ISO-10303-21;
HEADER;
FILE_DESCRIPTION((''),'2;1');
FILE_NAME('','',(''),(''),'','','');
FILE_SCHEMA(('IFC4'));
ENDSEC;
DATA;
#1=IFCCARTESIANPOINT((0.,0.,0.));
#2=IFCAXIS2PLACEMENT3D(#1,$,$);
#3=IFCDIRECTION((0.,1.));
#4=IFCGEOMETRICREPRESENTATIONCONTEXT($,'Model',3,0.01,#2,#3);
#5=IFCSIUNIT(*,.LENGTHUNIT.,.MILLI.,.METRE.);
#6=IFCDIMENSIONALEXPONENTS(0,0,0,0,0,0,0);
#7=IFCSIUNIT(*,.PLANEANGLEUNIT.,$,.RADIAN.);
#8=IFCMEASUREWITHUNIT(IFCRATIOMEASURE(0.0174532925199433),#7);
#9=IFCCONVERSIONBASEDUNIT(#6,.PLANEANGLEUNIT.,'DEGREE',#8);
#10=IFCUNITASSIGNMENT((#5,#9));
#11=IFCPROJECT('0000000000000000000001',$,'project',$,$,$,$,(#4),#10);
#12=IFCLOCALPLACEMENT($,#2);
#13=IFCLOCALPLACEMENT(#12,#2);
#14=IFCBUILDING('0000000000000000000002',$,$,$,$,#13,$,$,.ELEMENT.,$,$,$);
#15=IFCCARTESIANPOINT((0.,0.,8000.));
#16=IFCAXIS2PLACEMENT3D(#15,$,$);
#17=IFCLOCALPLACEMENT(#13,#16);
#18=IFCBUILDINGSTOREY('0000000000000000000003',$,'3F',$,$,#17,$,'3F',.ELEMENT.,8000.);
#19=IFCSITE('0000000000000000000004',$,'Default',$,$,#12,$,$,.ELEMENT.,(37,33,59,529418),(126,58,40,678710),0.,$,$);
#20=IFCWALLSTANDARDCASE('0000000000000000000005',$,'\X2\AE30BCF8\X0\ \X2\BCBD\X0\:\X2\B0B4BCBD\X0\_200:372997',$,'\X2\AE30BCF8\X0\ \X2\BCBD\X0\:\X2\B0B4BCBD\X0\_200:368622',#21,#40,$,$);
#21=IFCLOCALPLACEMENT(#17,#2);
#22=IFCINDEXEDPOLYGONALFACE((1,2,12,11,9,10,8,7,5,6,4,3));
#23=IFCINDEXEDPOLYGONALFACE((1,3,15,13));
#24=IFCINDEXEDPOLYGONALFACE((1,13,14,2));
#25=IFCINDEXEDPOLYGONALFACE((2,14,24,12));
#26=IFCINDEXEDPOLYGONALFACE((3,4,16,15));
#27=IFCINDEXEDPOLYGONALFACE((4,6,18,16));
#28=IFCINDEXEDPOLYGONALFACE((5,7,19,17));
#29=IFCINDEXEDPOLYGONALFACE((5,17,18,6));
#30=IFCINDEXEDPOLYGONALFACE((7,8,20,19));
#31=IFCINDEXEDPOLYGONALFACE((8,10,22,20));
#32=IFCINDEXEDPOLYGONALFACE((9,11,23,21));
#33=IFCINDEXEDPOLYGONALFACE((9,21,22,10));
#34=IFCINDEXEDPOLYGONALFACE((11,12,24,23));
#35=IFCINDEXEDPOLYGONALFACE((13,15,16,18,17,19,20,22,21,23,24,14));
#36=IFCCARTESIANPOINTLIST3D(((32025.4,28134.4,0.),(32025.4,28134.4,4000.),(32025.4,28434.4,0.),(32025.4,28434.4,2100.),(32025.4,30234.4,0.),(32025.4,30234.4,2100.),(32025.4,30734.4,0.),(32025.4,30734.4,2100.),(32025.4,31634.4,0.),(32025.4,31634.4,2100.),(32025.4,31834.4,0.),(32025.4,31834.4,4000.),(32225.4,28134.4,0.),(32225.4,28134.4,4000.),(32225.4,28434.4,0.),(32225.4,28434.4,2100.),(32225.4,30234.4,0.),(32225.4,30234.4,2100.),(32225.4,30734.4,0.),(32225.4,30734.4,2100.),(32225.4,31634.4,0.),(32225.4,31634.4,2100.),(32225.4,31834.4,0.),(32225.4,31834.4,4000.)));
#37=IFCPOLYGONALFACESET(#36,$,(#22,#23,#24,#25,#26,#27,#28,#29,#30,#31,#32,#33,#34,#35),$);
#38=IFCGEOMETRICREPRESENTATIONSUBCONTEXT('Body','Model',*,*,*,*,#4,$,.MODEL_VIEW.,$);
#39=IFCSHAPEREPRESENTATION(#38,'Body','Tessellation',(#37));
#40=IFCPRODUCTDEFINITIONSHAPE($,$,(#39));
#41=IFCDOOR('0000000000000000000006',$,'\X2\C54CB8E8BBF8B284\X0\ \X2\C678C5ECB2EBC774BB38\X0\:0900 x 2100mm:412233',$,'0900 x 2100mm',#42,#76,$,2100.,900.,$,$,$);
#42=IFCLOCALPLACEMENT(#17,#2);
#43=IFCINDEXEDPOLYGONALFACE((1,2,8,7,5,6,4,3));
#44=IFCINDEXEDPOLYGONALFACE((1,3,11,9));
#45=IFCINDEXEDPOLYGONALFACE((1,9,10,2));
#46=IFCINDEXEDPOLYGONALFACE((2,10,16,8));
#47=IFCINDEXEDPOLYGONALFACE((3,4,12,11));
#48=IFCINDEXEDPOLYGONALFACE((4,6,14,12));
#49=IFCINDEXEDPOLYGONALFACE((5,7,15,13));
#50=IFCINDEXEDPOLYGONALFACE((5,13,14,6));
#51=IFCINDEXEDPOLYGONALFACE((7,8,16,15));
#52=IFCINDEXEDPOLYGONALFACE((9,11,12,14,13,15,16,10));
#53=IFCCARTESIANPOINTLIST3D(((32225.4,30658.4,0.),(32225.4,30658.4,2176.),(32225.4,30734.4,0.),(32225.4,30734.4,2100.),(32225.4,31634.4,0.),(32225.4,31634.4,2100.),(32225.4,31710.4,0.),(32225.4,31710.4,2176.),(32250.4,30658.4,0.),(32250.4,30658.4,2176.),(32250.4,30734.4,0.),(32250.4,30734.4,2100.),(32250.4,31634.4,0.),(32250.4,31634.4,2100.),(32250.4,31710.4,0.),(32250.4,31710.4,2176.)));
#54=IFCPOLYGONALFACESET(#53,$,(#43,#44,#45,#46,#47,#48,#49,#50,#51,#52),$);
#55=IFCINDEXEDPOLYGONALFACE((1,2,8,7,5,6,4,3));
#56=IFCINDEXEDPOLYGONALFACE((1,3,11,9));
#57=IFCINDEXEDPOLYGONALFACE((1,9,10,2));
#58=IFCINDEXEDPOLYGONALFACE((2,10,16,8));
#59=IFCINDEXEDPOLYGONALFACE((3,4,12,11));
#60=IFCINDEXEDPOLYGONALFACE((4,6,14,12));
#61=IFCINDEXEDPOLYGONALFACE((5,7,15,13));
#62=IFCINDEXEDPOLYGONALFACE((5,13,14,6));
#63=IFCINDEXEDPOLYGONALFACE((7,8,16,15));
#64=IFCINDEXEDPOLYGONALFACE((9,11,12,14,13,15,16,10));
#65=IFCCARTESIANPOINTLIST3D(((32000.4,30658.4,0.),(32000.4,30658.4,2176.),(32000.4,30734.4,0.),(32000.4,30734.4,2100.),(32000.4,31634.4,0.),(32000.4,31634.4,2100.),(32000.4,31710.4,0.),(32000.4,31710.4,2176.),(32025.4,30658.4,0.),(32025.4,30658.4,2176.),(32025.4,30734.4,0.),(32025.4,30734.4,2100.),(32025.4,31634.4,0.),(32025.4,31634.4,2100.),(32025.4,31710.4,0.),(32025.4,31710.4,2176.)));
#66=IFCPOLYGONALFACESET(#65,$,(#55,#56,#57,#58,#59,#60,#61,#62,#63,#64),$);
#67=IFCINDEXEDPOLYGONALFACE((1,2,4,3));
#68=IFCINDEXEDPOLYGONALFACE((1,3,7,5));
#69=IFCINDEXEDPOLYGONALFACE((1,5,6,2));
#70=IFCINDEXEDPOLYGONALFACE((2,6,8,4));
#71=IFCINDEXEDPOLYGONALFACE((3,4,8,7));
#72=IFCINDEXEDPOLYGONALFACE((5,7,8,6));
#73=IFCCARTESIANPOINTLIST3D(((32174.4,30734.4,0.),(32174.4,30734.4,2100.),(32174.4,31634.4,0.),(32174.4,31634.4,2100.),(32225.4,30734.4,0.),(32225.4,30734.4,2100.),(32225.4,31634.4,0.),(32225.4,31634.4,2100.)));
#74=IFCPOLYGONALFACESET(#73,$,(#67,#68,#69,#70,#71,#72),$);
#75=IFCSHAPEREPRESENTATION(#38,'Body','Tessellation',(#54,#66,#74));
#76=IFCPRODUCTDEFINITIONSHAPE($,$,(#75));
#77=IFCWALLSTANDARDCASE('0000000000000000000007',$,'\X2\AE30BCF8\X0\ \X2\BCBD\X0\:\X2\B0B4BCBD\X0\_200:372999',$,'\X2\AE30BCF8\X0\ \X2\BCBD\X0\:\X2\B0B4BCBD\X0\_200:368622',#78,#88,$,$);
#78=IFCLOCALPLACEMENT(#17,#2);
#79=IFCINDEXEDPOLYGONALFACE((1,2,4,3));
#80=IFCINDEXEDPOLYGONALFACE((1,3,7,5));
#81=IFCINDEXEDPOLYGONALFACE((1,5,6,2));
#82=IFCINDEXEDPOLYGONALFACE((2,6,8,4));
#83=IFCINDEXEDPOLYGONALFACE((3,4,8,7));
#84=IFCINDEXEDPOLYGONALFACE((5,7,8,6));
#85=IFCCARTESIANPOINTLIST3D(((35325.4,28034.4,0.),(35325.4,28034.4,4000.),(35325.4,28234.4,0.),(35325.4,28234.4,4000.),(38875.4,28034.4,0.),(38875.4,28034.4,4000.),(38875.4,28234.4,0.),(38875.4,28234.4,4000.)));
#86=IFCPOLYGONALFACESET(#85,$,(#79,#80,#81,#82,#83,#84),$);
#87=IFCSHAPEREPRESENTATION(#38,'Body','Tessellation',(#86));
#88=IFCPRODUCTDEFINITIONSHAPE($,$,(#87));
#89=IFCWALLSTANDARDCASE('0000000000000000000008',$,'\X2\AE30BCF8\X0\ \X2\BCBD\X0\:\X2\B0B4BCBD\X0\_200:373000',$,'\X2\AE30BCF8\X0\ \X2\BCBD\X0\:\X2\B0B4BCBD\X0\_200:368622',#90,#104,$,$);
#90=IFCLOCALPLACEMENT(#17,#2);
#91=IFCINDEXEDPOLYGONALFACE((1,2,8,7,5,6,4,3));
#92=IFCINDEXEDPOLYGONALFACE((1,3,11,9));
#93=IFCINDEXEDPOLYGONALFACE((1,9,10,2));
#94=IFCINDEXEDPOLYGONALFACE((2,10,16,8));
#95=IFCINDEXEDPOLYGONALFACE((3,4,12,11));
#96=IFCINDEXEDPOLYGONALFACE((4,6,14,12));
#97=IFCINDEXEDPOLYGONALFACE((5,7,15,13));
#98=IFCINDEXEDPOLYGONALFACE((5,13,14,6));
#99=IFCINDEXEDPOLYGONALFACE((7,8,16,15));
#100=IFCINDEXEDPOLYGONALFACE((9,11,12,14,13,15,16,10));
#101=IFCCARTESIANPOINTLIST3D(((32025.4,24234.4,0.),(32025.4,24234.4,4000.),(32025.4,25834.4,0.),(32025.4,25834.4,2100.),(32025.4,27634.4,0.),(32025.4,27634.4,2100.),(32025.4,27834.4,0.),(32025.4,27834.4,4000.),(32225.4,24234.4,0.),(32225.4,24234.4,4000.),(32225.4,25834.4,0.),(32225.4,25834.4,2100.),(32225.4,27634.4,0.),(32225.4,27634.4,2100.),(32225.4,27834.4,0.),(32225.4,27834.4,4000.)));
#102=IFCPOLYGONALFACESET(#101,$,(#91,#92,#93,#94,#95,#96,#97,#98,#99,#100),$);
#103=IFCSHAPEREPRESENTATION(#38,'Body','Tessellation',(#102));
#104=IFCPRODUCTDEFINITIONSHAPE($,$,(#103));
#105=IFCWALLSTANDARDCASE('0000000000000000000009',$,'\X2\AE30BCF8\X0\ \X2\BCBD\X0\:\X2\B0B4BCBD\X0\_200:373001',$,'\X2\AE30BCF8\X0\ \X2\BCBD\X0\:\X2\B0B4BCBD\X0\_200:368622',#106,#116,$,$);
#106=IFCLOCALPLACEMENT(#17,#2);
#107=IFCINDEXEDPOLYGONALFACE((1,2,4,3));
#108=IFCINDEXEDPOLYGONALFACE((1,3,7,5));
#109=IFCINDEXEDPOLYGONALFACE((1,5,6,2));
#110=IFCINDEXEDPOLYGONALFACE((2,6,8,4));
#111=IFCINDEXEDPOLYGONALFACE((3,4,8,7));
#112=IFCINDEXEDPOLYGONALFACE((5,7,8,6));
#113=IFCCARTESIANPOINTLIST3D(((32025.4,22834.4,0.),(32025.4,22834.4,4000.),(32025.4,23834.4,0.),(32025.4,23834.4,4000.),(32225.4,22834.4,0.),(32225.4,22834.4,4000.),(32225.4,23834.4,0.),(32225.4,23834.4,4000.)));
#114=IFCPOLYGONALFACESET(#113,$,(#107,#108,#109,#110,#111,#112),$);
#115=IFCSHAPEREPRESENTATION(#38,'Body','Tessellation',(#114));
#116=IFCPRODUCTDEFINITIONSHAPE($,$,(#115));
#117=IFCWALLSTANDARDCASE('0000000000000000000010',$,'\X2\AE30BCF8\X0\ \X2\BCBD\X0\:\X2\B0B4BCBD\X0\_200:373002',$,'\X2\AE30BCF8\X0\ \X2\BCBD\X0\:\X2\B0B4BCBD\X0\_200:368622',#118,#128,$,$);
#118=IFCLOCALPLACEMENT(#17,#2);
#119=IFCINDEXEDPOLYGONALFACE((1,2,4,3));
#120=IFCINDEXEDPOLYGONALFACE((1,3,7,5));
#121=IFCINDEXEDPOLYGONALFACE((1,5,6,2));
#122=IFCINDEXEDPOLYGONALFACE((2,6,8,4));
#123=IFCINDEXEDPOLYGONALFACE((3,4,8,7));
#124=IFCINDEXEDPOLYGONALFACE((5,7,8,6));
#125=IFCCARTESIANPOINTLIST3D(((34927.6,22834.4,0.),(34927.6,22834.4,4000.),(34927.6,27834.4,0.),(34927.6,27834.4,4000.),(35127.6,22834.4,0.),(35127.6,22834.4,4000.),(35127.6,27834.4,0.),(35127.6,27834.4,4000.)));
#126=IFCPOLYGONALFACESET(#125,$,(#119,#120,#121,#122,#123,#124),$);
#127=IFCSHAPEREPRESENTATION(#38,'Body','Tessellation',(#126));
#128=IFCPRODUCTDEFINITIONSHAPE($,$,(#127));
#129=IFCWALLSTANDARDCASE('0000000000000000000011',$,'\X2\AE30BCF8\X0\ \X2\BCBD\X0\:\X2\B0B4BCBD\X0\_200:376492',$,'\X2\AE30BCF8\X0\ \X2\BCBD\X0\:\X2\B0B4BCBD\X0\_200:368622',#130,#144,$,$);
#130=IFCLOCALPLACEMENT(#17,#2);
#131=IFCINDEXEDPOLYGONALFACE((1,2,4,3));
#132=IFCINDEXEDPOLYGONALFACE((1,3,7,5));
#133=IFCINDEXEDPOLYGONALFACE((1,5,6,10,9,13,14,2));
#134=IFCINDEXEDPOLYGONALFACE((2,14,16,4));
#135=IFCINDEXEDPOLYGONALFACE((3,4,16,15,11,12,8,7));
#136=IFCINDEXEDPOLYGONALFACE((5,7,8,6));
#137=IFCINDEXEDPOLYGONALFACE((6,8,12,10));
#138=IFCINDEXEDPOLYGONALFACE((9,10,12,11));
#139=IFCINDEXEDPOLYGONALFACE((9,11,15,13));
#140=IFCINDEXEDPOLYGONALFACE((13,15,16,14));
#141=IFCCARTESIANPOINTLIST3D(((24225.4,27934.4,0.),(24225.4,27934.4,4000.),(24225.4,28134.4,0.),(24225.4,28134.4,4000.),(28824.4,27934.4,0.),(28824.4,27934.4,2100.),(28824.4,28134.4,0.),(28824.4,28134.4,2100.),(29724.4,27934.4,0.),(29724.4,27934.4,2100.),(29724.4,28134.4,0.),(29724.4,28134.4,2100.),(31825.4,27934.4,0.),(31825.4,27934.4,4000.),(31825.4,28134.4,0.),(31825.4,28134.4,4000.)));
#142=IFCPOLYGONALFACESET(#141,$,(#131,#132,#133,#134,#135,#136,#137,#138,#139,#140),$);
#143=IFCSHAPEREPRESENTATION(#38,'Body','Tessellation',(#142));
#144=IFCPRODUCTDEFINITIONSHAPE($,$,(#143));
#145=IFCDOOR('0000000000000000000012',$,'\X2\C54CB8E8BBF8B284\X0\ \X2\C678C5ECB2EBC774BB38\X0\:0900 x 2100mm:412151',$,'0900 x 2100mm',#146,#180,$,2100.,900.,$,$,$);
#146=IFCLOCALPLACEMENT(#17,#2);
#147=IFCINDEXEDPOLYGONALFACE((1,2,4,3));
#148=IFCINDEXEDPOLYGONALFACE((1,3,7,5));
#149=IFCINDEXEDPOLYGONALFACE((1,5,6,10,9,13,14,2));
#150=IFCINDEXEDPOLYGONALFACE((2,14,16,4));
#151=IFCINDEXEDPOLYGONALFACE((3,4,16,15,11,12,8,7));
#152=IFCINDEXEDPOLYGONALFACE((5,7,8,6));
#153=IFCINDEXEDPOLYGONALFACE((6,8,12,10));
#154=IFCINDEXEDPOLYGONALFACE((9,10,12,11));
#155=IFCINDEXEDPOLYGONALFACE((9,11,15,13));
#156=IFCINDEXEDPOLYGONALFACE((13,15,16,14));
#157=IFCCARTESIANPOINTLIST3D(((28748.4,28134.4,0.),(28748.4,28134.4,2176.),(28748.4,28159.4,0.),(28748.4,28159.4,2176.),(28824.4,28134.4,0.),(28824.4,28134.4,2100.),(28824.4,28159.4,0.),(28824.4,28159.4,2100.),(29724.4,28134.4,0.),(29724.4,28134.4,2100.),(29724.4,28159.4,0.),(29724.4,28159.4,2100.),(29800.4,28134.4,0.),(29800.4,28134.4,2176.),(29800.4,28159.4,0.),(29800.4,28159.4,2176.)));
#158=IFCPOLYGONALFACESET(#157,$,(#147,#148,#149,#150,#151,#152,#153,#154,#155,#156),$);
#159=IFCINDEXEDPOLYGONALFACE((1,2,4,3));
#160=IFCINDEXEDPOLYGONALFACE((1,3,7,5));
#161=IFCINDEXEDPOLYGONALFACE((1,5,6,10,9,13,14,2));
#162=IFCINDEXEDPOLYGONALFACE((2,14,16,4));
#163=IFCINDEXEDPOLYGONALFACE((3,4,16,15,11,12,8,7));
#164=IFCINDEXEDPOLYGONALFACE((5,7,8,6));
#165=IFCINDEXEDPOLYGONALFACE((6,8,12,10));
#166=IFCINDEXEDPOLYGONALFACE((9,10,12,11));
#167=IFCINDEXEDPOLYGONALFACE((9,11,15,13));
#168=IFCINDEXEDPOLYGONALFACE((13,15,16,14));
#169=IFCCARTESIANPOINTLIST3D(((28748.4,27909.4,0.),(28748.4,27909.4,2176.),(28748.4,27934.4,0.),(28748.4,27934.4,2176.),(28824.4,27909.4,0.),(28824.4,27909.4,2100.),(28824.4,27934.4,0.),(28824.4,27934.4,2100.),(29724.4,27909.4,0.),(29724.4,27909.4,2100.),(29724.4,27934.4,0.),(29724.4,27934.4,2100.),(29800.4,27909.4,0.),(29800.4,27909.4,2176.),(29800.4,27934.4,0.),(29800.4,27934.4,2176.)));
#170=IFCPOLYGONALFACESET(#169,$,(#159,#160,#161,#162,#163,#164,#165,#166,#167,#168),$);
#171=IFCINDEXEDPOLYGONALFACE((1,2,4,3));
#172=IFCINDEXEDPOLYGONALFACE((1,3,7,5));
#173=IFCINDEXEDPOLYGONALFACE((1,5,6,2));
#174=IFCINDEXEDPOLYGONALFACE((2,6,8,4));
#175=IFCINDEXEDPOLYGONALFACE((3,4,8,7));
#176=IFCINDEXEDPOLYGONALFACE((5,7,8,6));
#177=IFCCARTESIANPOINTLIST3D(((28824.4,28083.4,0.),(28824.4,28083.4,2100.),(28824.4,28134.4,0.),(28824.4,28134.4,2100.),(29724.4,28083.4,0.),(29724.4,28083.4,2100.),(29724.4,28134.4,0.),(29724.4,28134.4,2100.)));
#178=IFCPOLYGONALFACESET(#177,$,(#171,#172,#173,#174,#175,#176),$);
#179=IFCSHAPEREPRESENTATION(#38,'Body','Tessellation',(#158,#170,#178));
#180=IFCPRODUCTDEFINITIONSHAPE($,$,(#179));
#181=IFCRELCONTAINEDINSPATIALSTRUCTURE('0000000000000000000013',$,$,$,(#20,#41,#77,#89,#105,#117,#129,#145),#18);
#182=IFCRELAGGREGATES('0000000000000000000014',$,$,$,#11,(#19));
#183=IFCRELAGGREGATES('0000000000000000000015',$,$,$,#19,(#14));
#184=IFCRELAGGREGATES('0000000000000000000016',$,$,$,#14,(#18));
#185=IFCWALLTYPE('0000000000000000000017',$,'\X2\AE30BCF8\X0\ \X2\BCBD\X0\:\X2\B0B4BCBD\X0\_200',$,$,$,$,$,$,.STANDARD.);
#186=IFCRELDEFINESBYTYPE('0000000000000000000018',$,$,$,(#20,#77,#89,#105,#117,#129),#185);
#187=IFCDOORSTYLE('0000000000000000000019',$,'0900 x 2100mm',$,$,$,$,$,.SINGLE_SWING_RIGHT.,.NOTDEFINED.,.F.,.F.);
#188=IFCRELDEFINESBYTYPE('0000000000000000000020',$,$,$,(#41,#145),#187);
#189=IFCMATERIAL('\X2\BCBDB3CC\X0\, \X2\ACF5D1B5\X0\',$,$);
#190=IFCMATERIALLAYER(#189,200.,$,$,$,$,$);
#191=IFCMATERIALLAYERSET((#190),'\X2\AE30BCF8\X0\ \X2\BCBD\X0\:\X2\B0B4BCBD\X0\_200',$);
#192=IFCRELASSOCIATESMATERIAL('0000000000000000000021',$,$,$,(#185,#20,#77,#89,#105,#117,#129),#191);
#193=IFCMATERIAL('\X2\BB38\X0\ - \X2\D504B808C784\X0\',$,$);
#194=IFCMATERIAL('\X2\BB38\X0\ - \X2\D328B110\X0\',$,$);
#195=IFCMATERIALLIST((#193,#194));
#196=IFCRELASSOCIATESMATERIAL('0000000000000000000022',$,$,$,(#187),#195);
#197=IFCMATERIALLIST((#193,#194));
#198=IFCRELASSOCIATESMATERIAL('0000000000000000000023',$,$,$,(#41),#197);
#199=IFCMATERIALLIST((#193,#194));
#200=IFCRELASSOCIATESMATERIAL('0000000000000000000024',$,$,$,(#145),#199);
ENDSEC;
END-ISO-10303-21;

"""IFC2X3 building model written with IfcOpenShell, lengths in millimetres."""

from ifc_helpers import new_model, entity, si_unit, converted_unit, direction, frame, frame_2d, origin, place, context, subcontext, project, spatial, polyline, rectangle, outline, extrude, source, transform, mapped, material, material_list, layer, layer_set, layer_usage, type_object, type_shapes, element, fill, save


model = new_model("IFC2X3")

# Units and contexts
model_context = context("Model", 3, precision=0.01, world=origin(), true_north=direction((0.0, 1.0)))
body_context = subcontext(model_context, "Body", "Model", "MODEL_VIEW")
ifc_project = project(units=[si_unit("LENGTHUNIT", "METRE", prefix="MILLI"), converted_unit("PLANEANGLEUNIT", "DEGREE", entity("IfcRatioMeasure", 0.0174532925199433), si_unit("PLANEANGLEUNIT", "RADIAN"), dimensions=[0, 0, 0, 0, 0, 0, 0])], contexts=[model_context])

# Site, building, storey
site_placement = place(None, origin())
site = spatial("IfcSite", under=ifc_project, at=site_placement, Name="Default", CompositionType="ELEMENT", RefLatitude=(37, 33, 59, 529418), RefLongitude=(126, 58, 40, 678710), RefElevation=0.0)
building_placement = place(site_placement, origin())
building = spatial("IfcBuilding", under=site, at=building_placement, CompositionType="ELEMENT")
storey_placement = place(building_placement, frame((0.0, 0.0, 8000.0)))
storey = spatial("IfcBuildingStorey", under=building, at=storey_placement, Name="3F", LongName="3F", CompositionType="ELEMENT", Elevation=8000.0)

# Wall, openings, door
ifc_material_1 = material(Name="벽돌, 공통")
ifc_layer_1 = layer(ifc_material_1, 200.0)
ifc_layer_set_1 = layer_set([ifc_layer_1], Name="기본 벽:내벽_200")
ifc_layer_usage_1 = layer_usage(ifc_layer_set_1, "AXIS2", "NEGATIVE", 100.0)
wall_type_1 = type_object("IfcWallType", Name="기본 벽:내벽_200", PredefinedType="STANDARD", material=ifc_layer_set_1)
wall_1_placement = place(storey_placement, frame((32125.4, 31834.4, 0.0), z_axis=(0.0, 0.0, 1.0), x_axis=(0.0, -1.0, 0.0)))
wall_1 = element("IfcWallStandardCase", 1, at=wall_1_placement, inside=storey, type_object=wall_type_1, material=ifc_layer_usage_1, Name="기본 벽:내벽_200:372997", ObjectType="기본 벽:내벽_200:368622", context=body_context, shape_type="SweptSolid", body=[
    extrude(rectangle(XDim=3700.0, YDim=200.0, at=frame_2d((1850.0, 0.0), x_axis=(-1.0, 0.0))), origin(), (0.0, 0.0, 1.0), 4000.0),
])
opening_1_placement = place(wall_1_placement, frame((200.0, -100.0, 0.0)))
opening_1 = element("IfcOpeningElement", 2, at=opening_1_placement, cuts=wall_1, ObjectType="Opening", context=body_context, shape_type="SweptSolid", body=[
    extrude(rectangle(XDim=900.0, YDim=2100.0, at=frame_2d((1050.0, 450.0), x_axis=(0.0, 1.0))), frame((0.0, 0.0, 0.0), z_axis=(0.0, 1.0, 0.0), x_axis=(0.0, 0.0, 1.0)), (0.0, 0.0, 1.0), 200.0),
])
opening_2_placement = place(wall_1_placement, frame((3400.0, 100.0, 0.0)))
element("IfcOpeningElement", 3, at=opening_2_placement, cuts=wall_1, ObjectType="Opening", context=body_context, shape_type="SweptSolid", body=[
    extrude(rectangle(XDim=2100.0, YDim=1800.0, at=frame_2d((1050.0, 900.0), x_axis=(1.0, 0.0))), frame((0.0, 0.0, 0.0), z_axis=(0.0, -1.0, 0.0), x_axis=(0.0, 0.0, 1.0)), (0.0, 0.0, 1.0), 200.0),
])
ifc_material_2 = material(Name="문 - 프레임")
ifc_material_3 = material(Name="문 - 패널")
ifc_material_list_1 = material_list([ifc_material_2, ifc_material_3])
ifc_material_list_2 = material_list([ifc_material_2, ifc_material_3])
door_style_1 = type_object("IfcDoorStyle", Name="0900 x 2100mm", ConstructionType="NOTDEFINED", OperationType="SINGLE_SWING_RIGHT", ParameterTakesPrecedence=False, Sizeable=False, material=ifc_material_list_2)
shared_shape_1 = source(origin(), body_context, "Body", "SweptSolid", [
    extrude(outline(polyline([(-526.0, -1107.0), (526.0, -1107.0), (526.0, 1069.0), (450.0, 1069.0), (450.0, -1031.0), (-450.0, -1031.0), (-450.0, 1069.0), (-526.0, 1069.0), (-526.0, -1107.0)])), frame((450.0, 200.0, 1069.0), z_axis=(0.0, 1.0, 0.0), x_axis=(1.0, 0.0, 0.0)), (0.0, 0.0, 1.0), 25.0),
    extrude(outline(polyline([(-1107.0, -526.0), (1069.0, -526.0), (1069.0, -450.0), (-1031.0, -450.0), (-1031.0, 450.0), (1069.0, 450.0), (1069.0, 526.0), (-1107.0, 526.0), (-1107.0, -526.0)])), frame((450.0, -25.0, 1069.0), z_axis=(0.0, 1.0, 0.0), x_axis=(0.0, 0.0, -1.0)), (0.0, 0.0, 1.0), 25.0),
    extrude(rectangle(XDim=51.0, YDim=900.0, at=frame_2d((0.0, 0.0), x_axis=(1.0, 0.0))), frame((450.0, 174.5, 0.0), z_axis=(0.0, 0.0, 1.0), x_axis=(0.0, 1.0, 0.0)), (0.0, 0.0, 1.0), 2100.0),
])
type_shapes(door_style_1, [shared_shape_1])
door_1_placement = place(opening_1_placement, frame((0.0, 0.0, 0.0)))
door_1 = element("IfcDoor", 4, at=door_1_placement, inside=storey, type_object=door_style_1, material=ifc_material_list_1, Name="알루미늄 외여닫이문:0900 x 2100mm:412233", ObjectType="0900 x 2100mm", OverallHeight=2100.0, OverallWidth=900.0, context=body_context, shape_type="MappedRepresentation", body=[
    mapped(shared_shape_1, transform((0.0, 0.0, 0.0), scale=1.0)),
])
fill(opening_1, door_1)

# Wall
ifc_layer_usage_2 = layer_usage(ifc_layer_set_1, "AXIS2", "NEGATIVE", 100.0)
wall_2_placement = place(storey_placement, frame((35325.4, 28134.4, 0.0)))
element("IfcWallStandardCase", 5, at=wall_2_placement, inside=storey, type_object=wall_type_1, material=ifc_layer_usage_2, Name="기본 벽:내벽_200:372999", ObjectType="기본 벽:내벽_200:368622", context=body_context, shape_type="SweptSolid", body=[
    extrude(rectangle(XDim=3550.0, YDim=200.0, at=frame_2d((1775.0, 0.0), x_axis=(-1.0, 0.0))), origin(), (0.0, 0.0, 1.0), 4000.0),
])

# Wall, opening
ifc_layer_usage_3 = layer_usage(ifc_layer_set_1, "AXIS2", "NEGATIVE", 100.0)
wall_3_placement = place(storey_placement, frame((32125.4, 24234.4, 0.0), z_axis=(0.0, 0.0, 1.0), x_axis=(0.0, 1.0, 0.0)))
wall_3 = element("IfcWallStandardCase", 6, at=wall_3_placement, inside=storey, type_object=wall_type_1, material=ifc_layer_usage_3, Name="기본 벽:내벽_200:373000", ObjectType="기본 벽:내벽_200:368622", context=body_context, shape_type="SweptSolid", body=[
    extrude(rectangle(XDim=3600.0, YDim=200.0, at=frame_2d((1800.0, 0.0), x_axis=(-1.0, 0.0))), origin(), (0.0, 0.0, 1.0), 4000.0),
])
opening_3_placement = place(wall_3_placement, frame((1600.0, -100.0, 0.0)))
element("IfcOpeningElement", 7, at=opening_3_placement, cuts=wall_3, ObjectType="Opening", context=body_context, shape_type="SweptSolid", body=[
    extrude(rectangle(XDim=2100.0, YDim=1800.0, at=frame_2d((1050.0, 900.0), x_axis=(1.0, 0.0))), frame((0.0, 0.0, 0.0), z_axis=(0.0, 1.0, 0.0), x_axis=(0.0, 0.0, 1.0)), (0.0, 0.0, 1.0), 200.0),
])

# Walls
ifc_layer_usage_4 = layer_usage(ifc_layer_set_1, "AXIS2", "NEGATIVE", 100.0)
wall_4_placement = place(storey_placement, frame((32125.4, 22834.4, 0.0), z_axis=(0.0, 0.0, 1.0), x_axis=(0.0, 1.0, 0.0)))
element("IfcWallStandardCase", 8, at=wall_4_placement, inside=storey, type_object=wall_type_1, material=ifc_layer_usage_4, Name="기본 벽:내벽_200:373001", ObjectType="기본 벽:내벽_200:368622", context=body_context, shape_type="SweptSolid", body=[
    extrude(rectangle(XDim=1000.0, YDim=200.0, at=frame_2d((500.0, 0.0), x_axis=(-1.0, 0.0))), origin(), (0.0, 0.0, 1.0), 4000.0),
])
ifc_layer_usage_5 = layer_usage(ifc_layer_set_1, "AXIS2", "NEGATIVE", 100.0)
wall_5_placement = place(storey_placement, frame((35027.6, 22834.4, 0.0), z_axis=(0.0, 0.0, 1.0), x_axis=(0.0, 1.0, 0.0)))
element("IfcWallStandardCase", 9, at=wall_5_placement, inside=storey, type_object=wall_type_1, material=ifc_layer_usage_5, Name="기본 벽:내벽_200:373002", ObjectType="기본 벽:내벽_200:368622", context=body_context, shape_type="SweptSolid", body=[
    extrude(rectangle(XDim=5000.0, YDim=200.0, at=frame_2d((2500.0, 0.0), x_axis=(-1.0, 0.0))), origin(), (0.0, 0.0, 1.0), 4000.0),
])

# Wall, opening, door
ifc_layer_usage_6 = layer_usage(ifc_layer_set_1, "AXIS2", "NEGATIVE", 100.0)
wall_6_placement = place(storey_placement, frame((24225.4, 28034.4, 0.0)))
wall_6 = element("IfcWallStandardCase", 10, at=wall_6_placement, inside=storey, type_object=wall_type_1, material=ifc_layer_usage_6, Name="기본 벽:내벽_200:376492", ObjectType="기본 벽:내벽_200:368622", context=body_context, shape_type="SweptSolid", body=[
    extrude(rectangle(XDim=7600.0, YDim=200.0, at=frame_2d((3800.0, 0.0), x_axis=(-1.0, 0.0))), origin(), (0.0, 0.0, 1.0), 4000.0),
])
opening_4_placement = place(wall_6_placement, frame((4599.0, -100.0, 0.0)))
opening_4 = element("IfcOpeningElement", 11, at=opening_4_placement, cuts=wall_6, ObjectType="Opening", context=body_context, shape_type="SweptSolid", body=[
    extrude(rectangle(XDim=900.0, YDim=2100.0, at=frame_2d((1050.0, 450.0), x_axis=(0.0, 1.0))), frame((0.0, 0.0, 0.0), z_axis=(0.0, 1.0, 0.0), x_axis=(0.0, 0.0, 1.0)), (0.0, 0.0, 1.0), 200.0),
])
ifc_material_list_3 = material_list([ifc_material_2, ifc_material_3])
door_2_placement = place(opening_4_placement, frame((0.0, 0.0, 0.0)))
door_2 = element("IfcDoor", 12, at=door_2_placement, inside=storey, type_object=door_style_1, material=ifc_material_list_3, Name="알루미늄 외여닫이문:0900 x 2100mm:412151", ObjectType="0900 x 2100mm", OverallHeight=2100.0, OverallWidth=900.0, context=body_context, shape_type="MappedRepresentation", body=[
    mapped(shared_shape_1, transform((0.0, 0.0, 0.0), scale=1.0)),
])
fill(opening_4, door_2)

save(model, "model.ifc")
